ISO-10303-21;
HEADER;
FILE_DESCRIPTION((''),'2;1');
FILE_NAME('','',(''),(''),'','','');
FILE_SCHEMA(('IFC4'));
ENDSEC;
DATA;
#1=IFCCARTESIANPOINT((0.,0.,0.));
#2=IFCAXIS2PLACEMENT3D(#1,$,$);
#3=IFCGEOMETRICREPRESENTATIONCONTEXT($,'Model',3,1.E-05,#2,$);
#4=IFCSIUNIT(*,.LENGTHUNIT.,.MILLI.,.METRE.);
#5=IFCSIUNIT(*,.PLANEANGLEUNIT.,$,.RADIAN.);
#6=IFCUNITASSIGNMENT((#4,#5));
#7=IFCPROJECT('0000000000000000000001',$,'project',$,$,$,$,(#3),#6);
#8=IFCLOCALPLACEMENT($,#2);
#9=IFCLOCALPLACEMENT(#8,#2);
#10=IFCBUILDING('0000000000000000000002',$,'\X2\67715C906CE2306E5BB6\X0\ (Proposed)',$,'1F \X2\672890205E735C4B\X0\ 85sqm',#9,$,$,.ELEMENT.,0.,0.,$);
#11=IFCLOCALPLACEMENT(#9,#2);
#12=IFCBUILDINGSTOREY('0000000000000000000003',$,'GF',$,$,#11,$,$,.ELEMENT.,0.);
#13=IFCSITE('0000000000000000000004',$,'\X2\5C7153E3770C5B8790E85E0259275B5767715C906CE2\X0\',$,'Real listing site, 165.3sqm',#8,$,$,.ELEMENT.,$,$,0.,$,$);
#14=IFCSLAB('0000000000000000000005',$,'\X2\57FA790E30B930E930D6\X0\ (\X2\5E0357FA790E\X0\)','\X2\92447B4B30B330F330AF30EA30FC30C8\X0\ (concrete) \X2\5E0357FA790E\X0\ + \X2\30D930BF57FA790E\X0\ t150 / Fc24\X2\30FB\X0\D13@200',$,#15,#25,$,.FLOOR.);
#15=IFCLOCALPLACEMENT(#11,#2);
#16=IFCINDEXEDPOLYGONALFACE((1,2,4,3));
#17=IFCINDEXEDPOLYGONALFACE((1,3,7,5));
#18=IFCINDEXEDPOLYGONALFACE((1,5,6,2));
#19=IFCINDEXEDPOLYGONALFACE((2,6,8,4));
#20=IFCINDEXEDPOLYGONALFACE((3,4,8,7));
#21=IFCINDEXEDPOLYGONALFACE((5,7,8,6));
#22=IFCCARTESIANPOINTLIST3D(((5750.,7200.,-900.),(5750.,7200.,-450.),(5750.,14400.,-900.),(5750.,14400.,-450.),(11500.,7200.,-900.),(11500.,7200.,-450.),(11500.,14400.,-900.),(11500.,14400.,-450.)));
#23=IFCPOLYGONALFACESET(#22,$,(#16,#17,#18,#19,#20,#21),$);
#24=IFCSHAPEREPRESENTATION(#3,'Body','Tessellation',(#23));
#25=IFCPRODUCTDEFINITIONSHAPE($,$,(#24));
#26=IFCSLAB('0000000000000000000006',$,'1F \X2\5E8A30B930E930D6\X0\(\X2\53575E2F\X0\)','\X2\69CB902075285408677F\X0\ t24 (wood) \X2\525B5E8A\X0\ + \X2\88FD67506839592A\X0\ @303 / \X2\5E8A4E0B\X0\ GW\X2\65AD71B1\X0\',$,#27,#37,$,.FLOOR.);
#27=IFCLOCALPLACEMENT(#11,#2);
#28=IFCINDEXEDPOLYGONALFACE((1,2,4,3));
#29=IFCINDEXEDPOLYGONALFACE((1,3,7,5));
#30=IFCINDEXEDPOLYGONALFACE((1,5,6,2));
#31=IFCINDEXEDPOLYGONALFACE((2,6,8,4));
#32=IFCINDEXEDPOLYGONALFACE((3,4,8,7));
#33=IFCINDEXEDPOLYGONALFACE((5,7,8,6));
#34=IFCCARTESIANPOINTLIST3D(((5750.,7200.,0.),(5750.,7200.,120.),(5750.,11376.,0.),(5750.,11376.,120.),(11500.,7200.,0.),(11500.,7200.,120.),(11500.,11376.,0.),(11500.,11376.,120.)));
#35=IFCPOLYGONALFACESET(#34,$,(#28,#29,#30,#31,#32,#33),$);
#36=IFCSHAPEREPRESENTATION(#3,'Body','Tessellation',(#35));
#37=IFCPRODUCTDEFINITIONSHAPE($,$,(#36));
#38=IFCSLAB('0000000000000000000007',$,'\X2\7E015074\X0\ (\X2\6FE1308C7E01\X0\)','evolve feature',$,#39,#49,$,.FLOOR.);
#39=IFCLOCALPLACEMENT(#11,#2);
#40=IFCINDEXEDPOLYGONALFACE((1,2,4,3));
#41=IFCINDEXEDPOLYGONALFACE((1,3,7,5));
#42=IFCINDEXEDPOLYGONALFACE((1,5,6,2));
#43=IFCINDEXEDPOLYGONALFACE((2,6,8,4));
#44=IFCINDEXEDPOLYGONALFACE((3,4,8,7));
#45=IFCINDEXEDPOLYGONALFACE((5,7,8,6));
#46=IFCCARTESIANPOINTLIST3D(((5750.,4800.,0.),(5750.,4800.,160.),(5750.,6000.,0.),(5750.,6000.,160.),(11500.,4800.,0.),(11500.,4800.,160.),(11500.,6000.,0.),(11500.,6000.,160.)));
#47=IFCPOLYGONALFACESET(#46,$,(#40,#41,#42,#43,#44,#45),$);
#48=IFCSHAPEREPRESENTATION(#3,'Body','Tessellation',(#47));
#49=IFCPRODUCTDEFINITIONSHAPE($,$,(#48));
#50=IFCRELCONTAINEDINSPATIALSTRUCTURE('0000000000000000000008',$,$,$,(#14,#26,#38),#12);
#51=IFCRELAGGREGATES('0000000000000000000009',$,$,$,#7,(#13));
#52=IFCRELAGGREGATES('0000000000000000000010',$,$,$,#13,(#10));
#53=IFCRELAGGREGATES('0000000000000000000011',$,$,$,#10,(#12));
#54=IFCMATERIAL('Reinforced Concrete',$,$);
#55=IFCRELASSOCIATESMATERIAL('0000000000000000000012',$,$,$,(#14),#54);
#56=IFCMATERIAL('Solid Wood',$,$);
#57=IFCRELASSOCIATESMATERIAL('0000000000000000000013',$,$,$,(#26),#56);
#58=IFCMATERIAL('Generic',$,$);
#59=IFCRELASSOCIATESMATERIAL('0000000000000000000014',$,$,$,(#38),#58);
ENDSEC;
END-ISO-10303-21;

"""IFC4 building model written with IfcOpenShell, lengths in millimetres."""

from ifc_helpers import new_model, si_unit, frame, frame_2d, origin, place, context, project, spatial, rectangle, extrude, material, element, save


model = new_model("IFC4")

# Units and contexts
model_context = context("Model", 3, precision=1e-05, world=origin())
ifc_project = project(units=[si_unit("LENGTHUNIT", "METRE", prefix="MILLI"), si_unit("PLANEANGLEUNIT", "RADIAN")], contexts=[model_context])

# Site, building, storey
site_placement = place(None, origin())
site = spatial("IfcSite", under=ifc_project, at=site_placement, Name="山口県宇部市大字東岐波", ObjectType="Real listing site, 165.3sqm", CompositionType="ELEMENT", RefElevation=0.0)
building_placement = place(site_placement, origin())
building = spatial("IfcBuilding", under=site, at=building_placement, Name="東岐波の家 (Proposed)", ObjectType="1F 木造平屋 85sqm", CompositionType="ELEMENT", ElevationOfRefHeight=0.0, ElevationOfTerrain=0.0)
storey_placement = place(building_placement, origin())
storey = spatial("IfcBuildingStorey", under=building, at=storey_placement, Name="GF", CompositionType="ELEMENT", Elevation=0.0)

# Slabs
ifc_material_1 = material(Name="Reinforced Concrete")
slab_1_placement = place(storey_placement, frame((2875.0, 3600.0, -450.0)))
element("IfcSlab", 1, at=slab_1_placement, inside=storey, material=ifc_material_1, Name="基礎スラブ (布基礎)", Description="鉄筋コンクリート (concrete) 布基礎 + ベタ基礎 t150 / Fc24・D13@200", PredefinedType="FLOOR", context=model_context, shape_type="SweptSolid", body=[
    extrude(rectangle(XDim=5750.0, YDim=7200.0, at=frame_2d((2875.0, 3600.0))), frame((2875.0, 3600.0, -450.0)), (0.0, 0.0, 1.0), 450.0),
])
ifc_material_2 = material(Name="Solid Wood")
slab_2_placement = place(storey_placement, frame((2875.0, 3600.0, 0.0)))
element("IfcSlab", 2, at=slab_2_placement, inside=storey, material=ifc_material_2, Name="1F 床スラブ(南帯)", Description="構造用合板 t24 (wood) 剛床 + 製材根太 @303 / 床下 GW断熱", PredefinedType="FLOOR", context=model_context, shape_type="SweptSolid", body=[
    extrude(rectangle(XDim=5750.0, YDim=4176.0, at=frame_2d((2875.0, 2088.0))), frame((2875.0, 3600.0, 0.0)), (0.0, 0.0, 1.0), 120.0),
])
ifc_material_3 = material(Name="Generic")
slab_3_placement = place(storey_placement, frame((2875.0, 2400.0, 0.0)))
element("IfcSlab", 3, at=slab_3_placement, inside=storey, material=ifc_material_3, Name="縁側 (濡れ縁)", Description="evolve feature", PredefinedType="FLOOR", context=model_context, shape_type="SweptSolid", body=[
    extrude(rectangle(XDim=5750.0, YDim=1200.0, at=frame_2d((2875.0, 600.0))), frame((2875.0, 2400.0, 0.0)), (0.0, 0.0, 1.0), 160.0),
])

save(model, "model.ifc")
